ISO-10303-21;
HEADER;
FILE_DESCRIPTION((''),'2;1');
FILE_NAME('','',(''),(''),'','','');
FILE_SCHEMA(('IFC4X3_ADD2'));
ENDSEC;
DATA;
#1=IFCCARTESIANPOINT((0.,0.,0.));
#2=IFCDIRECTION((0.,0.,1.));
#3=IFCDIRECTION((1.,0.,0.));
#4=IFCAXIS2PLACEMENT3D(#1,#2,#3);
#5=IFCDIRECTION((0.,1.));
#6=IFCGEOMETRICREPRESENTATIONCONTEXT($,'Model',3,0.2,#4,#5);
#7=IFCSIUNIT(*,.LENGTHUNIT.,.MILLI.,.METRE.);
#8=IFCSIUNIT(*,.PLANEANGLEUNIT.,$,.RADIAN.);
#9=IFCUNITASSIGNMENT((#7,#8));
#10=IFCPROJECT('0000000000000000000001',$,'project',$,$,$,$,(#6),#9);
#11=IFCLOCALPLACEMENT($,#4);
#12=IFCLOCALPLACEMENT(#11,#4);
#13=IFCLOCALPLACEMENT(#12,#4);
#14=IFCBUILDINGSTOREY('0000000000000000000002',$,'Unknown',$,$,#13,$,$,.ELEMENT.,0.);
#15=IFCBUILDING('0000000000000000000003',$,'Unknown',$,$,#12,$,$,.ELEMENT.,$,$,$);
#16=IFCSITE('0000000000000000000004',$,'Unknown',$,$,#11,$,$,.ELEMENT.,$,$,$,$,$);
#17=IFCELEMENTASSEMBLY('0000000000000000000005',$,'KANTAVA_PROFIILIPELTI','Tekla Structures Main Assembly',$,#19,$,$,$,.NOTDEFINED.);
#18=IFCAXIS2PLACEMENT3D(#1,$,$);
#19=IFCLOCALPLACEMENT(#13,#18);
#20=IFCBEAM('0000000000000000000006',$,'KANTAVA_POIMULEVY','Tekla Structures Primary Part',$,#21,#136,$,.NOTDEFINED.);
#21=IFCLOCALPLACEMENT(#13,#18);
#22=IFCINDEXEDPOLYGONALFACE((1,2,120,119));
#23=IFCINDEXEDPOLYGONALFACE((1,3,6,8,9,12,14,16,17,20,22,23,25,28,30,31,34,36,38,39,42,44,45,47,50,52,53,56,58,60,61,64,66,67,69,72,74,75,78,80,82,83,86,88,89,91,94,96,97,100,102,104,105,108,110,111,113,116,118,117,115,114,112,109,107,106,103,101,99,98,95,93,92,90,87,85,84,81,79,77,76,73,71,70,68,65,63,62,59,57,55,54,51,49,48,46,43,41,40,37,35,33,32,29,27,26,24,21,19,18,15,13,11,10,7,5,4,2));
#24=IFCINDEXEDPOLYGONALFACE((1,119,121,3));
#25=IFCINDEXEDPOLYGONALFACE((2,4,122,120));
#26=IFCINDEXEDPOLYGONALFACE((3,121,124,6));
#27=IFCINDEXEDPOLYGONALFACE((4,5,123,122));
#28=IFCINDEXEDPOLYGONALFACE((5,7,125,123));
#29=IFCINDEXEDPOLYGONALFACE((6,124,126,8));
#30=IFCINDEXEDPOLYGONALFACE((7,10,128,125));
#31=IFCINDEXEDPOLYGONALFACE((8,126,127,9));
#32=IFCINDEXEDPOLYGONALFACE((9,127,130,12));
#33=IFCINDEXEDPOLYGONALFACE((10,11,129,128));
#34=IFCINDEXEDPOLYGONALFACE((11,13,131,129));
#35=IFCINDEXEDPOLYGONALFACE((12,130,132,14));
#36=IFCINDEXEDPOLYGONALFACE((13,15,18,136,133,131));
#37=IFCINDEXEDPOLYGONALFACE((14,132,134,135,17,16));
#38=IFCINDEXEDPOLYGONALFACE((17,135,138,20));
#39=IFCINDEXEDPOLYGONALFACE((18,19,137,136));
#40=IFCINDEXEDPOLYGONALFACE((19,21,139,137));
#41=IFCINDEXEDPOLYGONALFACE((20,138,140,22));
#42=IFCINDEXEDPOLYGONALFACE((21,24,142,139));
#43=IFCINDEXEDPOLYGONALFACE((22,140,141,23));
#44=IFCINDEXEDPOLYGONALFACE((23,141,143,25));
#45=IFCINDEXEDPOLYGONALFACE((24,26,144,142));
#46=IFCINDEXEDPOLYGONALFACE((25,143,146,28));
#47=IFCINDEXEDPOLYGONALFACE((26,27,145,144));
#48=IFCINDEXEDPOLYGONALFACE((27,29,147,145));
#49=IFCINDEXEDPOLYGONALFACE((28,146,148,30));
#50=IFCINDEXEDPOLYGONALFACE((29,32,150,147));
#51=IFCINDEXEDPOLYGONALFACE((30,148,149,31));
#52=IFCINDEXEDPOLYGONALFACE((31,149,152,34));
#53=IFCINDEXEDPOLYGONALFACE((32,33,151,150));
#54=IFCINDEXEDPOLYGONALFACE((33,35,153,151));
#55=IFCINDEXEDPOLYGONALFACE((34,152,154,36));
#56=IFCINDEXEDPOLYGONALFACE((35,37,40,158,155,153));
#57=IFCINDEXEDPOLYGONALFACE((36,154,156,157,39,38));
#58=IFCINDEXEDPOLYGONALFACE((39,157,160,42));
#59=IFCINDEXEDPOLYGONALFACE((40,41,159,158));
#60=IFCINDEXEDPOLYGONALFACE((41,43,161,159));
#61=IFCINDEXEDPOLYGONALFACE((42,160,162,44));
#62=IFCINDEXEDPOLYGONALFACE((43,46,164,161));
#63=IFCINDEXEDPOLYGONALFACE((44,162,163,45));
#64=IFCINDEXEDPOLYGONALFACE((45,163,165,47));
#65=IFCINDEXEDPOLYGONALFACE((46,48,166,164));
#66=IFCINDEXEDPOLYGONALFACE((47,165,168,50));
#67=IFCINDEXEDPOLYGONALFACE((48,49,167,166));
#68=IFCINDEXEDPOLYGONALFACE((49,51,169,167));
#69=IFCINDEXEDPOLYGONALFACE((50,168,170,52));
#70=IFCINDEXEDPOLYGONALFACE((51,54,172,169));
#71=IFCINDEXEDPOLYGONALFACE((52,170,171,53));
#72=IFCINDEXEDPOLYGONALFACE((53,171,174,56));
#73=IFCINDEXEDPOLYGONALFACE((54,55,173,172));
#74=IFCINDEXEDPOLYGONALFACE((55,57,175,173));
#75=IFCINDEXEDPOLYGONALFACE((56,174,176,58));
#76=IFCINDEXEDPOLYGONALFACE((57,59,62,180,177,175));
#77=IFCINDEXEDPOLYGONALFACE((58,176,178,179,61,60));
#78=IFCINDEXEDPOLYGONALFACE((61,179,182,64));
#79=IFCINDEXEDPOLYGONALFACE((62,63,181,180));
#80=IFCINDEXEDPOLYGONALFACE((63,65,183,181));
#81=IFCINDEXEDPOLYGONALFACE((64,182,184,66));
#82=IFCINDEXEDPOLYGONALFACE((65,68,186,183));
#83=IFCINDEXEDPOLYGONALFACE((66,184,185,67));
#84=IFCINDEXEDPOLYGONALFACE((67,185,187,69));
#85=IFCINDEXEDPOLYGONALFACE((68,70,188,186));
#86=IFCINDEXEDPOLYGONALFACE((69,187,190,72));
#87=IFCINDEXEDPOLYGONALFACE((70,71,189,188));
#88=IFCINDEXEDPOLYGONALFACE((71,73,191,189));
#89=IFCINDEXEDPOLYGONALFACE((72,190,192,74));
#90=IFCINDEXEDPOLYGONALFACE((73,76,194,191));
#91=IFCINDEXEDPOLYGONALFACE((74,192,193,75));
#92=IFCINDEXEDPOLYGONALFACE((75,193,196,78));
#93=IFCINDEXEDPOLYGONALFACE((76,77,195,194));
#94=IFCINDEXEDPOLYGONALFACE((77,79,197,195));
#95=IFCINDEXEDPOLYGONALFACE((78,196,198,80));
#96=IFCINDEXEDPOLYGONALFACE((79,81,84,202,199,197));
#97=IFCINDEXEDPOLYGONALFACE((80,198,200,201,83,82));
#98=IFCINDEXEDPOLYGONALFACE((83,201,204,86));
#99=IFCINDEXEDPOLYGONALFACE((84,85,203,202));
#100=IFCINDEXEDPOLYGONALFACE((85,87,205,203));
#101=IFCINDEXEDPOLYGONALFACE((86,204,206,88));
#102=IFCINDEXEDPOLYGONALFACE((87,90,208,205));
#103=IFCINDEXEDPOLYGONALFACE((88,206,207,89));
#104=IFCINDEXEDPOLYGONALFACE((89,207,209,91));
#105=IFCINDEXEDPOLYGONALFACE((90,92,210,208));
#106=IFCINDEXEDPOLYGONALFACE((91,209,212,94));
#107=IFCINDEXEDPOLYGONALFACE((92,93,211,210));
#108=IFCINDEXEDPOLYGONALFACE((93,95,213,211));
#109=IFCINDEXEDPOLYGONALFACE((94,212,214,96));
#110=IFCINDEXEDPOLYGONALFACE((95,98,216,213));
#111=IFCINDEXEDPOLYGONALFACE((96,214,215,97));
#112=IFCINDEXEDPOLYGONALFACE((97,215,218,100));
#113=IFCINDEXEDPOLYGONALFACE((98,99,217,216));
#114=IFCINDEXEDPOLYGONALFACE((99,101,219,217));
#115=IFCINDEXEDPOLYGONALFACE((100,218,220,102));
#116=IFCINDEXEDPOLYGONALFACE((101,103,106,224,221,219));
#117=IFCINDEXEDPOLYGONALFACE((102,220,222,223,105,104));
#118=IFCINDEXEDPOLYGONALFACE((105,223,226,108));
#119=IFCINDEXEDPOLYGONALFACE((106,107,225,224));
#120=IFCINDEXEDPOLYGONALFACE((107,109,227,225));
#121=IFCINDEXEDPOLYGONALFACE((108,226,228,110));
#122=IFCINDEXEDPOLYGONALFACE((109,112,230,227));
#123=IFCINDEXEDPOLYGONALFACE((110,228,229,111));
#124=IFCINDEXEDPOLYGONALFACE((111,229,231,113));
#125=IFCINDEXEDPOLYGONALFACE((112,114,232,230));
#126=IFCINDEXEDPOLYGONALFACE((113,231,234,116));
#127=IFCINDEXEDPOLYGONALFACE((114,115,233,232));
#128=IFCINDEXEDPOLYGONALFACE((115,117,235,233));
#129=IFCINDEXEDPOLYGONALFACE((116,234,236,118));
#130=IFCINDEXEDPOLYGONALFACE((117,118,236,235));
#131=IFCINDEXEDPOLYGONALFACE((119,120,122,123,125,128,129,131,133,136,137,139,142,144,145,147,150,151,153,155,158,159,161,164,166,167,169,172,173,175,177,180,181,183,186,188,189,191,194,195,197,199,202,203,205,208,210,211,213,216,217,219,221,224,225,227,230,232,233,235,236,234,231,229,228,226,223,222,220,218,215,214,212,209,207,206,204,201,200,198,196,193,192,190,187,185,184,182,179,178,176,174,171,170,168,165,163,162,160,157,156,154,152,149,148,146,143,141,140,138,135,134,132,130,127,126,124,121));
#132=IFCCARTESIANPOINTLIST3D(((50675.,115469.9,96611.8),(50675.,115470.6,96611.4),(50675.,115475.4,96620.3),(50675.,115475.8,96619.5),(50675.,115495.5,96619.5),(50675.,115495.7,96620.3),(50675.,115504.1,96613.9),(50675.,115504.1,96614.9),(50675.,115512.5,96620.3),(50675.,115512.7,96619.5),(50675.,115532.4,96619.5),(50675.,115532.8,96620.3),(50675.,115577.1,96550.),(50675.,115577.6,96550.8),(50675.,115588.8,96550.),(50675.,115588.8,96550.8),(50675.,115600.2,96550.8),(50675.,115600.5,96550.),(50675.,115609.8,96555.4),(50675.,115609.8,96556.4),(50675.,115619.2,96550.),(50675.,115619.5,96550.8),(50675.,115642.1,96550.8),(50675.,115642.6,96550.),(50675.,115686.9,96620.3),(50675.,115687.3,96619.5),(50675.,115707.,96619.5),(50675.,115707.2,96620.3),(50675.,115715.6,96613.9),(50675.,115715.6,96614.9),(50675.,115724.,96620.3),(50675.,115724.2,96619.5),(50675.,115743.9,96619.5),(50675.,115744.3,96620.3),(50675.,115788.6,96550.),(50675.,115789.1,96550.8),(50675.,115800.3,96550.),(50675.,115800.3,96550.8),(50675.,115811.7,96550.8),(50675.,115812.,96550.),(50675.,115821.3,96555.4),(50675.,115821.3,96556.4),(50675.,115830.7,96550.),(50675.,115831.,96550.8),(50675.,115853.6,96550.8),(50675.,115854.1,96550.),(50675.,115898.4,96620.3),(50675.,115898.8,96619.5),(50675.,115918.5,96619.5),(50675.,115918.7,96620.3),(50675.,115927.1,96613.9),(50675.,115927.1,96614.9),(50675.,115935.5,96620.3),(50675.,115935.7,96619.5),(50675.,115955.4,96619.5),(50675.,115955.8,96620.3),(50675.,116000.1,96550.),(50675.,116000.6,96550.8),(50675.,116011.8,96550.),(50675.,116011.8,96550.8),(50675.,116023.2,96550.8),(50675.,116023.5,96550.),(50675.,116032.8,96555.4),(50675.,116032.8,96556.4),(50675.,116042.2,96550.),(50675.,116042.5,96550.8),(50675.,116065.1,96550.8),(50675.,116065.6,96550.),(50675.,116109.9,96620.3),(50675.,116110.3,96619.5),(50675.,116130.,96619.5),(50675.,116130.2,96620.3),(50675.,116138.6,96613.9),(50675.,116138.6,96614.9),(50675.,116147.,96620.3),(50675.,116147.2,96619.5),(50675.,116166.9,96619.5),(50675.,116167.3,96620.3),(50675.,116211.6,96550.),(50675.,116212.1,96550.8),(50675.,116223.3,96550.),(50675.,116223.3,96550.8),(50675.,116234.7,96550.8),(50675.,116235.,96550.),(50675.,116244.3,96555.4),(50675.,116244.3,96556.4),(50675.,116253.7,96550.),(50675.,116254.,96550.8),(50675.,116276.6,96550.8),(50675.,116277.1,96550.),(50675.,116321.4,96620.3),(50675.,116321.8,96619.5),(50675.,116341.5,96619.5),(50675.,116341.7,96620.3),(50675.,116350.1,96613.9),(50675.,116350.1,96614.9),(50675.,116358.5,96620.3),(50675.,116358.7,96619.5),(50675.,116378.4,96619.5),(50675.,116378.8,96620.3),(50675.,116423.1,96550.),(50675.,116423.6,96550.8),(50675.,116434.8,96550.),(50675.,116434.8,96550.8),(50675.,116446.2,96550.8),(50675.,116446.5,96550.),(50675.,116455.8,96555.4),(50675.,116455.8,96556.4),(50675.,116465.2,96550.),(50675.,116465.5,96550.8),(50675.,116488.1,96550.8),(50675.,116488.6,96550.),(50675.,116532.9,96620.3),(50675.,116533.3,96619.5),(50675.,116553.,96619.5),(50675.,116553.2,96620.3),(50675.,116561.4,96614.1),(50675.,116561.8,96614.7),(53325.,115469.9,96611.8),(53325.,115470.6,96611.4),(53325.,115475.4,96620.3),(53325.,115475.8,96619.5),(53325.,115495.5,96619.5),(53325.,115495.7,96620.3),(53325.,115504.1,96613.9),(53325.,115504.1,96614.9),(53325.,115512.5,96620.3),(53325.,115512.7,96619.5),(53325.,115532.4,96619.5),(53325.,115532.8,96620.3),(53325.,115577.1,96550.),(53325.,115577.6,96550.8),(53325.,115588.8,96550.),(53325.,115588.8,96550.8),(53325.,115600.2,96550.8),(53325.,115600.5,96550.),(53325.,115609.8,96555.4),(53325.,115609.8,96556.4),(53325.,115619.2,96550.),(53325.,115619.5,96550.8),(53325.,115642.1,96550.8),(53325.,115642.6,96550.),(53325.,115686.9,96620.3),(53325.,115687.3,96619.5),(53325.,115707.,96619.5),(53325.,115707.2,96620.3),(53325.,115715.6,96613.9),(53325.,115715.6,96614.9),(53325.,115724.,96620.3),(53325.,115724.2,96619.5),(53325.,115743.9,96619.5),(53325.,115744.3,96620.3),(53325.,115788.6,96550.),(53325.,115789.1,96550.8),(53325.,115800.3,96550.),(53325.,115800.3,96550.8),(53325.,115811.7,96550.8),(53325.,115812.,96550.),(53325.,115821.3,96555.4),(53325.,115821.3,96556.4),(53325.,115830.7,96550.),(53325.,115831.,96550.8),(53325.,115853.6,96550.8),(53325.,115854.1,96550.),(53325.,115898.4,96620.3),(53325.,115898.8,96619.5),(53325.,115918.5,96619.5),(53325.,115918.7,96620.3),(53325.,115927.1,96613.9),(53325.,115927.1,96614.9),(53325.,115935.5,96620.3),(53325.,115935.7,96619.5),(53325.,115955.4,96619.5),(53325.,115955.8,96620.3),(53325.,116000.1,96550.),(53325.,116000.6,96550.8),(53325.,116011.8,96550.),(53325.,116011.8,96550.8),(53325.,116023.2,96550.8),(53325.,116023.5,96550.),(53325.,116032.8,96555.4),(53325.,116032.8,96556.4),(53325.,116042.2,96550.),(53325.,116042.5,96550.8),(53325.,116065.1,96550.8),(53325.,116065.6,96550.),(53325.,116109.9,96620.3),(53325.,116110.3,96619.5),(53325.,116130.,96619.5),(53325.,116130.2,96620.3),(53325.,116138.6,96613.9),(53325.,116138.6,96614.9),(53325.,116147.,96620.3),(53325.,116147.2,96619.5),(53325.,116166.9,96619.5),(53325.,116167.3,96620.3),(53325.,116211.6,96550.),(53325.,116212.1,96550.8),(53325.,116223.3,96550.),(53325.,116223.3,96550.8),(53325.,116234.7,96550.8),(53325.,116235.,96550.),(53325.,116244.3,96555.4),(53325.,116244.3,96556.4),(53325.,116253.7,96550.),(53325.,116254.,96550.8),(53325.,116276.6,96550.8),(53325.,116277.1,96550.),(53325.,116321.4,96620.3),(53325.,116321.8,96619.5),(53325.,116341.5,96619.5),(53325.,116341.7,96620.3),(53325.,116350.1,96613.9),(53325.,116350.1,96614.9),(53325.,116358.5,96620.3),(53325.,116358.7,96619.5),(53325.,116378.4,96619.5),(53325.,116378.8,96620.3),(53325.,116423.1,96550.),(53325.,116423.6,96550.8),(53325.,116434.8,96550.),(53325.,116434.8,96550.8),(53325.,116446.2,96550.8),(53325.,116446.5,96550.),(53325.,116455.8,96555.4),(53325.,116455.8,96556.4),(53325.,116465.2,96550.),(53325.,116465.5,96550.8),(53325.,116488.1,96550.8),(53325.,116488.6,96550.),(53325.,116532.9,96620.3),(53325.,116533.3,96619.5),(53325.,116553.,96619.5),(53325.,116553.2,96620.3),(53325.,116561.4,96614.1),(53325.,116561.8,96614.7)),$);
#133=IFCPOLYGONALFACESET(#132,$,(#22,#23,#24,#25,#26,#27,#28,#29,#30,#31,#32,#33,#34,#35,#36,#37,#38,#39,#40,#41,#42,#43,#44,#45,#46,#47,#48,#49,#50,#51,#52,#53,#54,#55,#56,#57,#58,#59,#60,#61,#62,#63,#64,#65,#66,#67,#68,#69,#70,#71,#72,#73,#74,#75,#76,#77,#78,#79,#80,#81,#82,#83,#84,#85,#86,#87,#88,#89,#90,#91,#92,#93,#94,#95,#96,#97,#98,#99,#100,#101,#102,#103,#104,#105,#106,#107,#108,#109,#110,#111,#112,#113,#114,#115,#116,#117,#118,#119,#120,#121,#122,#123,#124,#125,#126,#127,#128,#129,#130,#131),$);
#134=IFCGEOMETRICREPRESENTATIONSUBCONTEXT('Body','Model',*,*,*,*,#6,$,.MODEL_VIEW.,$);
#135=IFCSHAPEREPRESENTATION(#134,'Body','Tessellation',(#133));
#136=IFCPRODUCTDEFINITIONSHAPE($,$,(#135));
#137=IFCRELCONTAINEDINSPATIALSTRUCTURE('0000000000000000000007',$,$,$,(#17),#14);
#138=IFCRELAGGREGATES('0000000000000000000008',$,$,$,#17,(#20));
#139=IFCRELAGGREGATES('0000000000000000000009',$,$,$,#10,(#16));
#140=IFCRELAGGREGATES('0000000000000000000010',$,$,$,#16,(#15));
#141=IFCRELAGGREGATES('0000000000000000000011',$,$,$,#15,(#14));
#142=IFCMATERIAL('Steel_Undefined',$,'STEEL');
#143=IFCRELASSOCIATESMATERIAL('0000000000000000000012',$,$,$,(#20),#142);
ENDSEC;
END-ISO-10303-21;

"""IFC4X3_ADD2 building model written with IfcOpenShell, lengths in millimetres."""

from ifc_helpers import new_model, si_unit, direction, frame, origin_with_axes, place, context, subcontext, project, spatial, line, indexed_curve, outline, extrude, material, element, aggregate, save


model = new_model("IFC4X3_ADD2")

# Units and contexts
model_context = context("Model", 3, precision=0.2, world=origin_with_axes(), true_north=direction((0.0, 1.0)))
body_context = subcontext(model_context, "Body", "Model", "MODEL_VIEW")
ifc_project = project(units=[si_unit("LENGTHUNIT", "METRE", prefix="MILLI"), si_unit("PLANEANGLEUNIT", "RADIAN")], contexts=[model_context])

# Site, building, storey
site_placement = place(None, origin_with_axes())
site = spatial("IfcSite", under=ifc_project, at=site_placement, Name="Unknown", CompositionType="ELEMENT")
building_placement = place(site_placement, origin_with_axes())
building = spatial("IfcBuilding", under=site, at=building_placement, Name="Unknown", CompositionType="ELEMENT")
storey_placement = place(building_placement, origin_with_axes())
storey = spatial("IfcBuildingStorey", under=building, at=storey_placement, Name="Unknown", CompositionType="ELEMENT", Elevation=0.0)

# Element assembly, beam
ifc_material_1 = material(Name="Steel_Undefined", Category="STEEL")
assembly_1_placement = place(storey_placement, frame((53325.0, 116032.8, 96585.2), z_axis=(0.0, 1.0, 0.0), x_axis=(-1.0, 0.0, 0.0)))
assembly_1 = element("IfcElementAssembly", 1, at=assembly_1_placement, inside=storey, Name="KANTAVA_PROFIILIPELTI", Description="Tekla Structures Main Assembly", PredefinedType="NOTDEFINED")
beam_1_placement = place(assembly_1_placement, origin_with_axes())
beam_1 = element("IfcBeam", 2, at=beam_1_placement, material=ifc_material_1, Name="KANTAVA_POIMULEVY", Description="Tekla Structures Primary Part", PredefinedType="NOTDEFINED", context=body_context, shape_type="SolidModel", body=[
    extrude(outline(indexed_curve([(529.0, 29.6), (520.4, 35.1), (500.0, 35.1), (455.3, -34.4), (432.6, -34.4), (423.0, -28.8), (413.4, -34.4), (402.0, -34.4), (390.7, -34.4), (346.0, 35.1), (325.6, 35.1), (317.2, 29.7), (308.9, 35.1), (288.5, 35.1), (243.8, -34.4), (221.1, -34.4), (211.5, -28.8), (201.9, -34.4), (190.5, -34.4), (179.2, -34.4), (134.5, 35.1), (114.1, 35.1), (105.8, 29.7), (97.4, 35.1), (77.0, 35.1), (32.3, -34.4), (9.6, -34.4), (0.0, -28.8), (-9.6, -34.4), (-21.0, -34.4), (-32.3, -34.4), (-77.0, 35.1), (-97.4, 35.1), (-105.8, 29.7), (-114.1, 35.1), (-134.5, 35.1), (-179.2, -34.4), (-201.9, -34.4), (-211.5, -28.8), (-221.1, -34.4), (-232.5, -34.4), (-243.8, -34.4), (-288.5, 35.1), (-308.9, 35.1), (-317.2, 29.7), (-325.6, 35.1), (-346.0, 35.1), (-390.7, -34.4), (-413.4, -34.4), (-423.0, -28.8), (-432.6, -34.4), (-444.0, -34.4), (-455.3, -34.4), (-500.0, 35.1), (-520.4, 35.1), (-528.8, 29.7), (-537.1, 35.1), (-557.5, 35.1), (-562.9, 26.7), (-562.2, 26.2), (-557.0, 34.4), (-537.4, 34.4), (-528.8, 28.8), (-520.1, 34.4), (-500.5, 34.4), (-455.7, -35.1), (-444.0, -35.1), (-432.4, -35.1), (-423.0, -29.7), (-413.6, -35.1), (-390.3, -35.1), (-345.5, 34.4), (-325.9, 34.4), (-317.2, 28.8), (-308.6, 34.4), (-289.0, 34.4), (-244.2, -35.1), (-232.5, -35.1), (-220.9, -35.1), (-211.5, -29.7), (-202.1, -35.1), (-178.8, -35.1), (-134.0, 34.4), (-114.4, 34.4), (-105.8, 28.8), (-97.1, 34.4), (-77.5, 34.4), (-32.7, -35.1), (-21.0, -35.1), (-9.4, -35.1), (0.0, -29.7), (9.4, -35.1), (32.7, -35.1), (77.5, 34.4), (97.1, 34.4), (105.8, 28.8), (114.4, 34.4), (134.0, 34.4), (178.8, -35.1), (190.5, -35.1), (202.1, -35.1), (211.5, -29.7), (220.9, -35.1), (244.2, -35.1), (289.0, 34.4), (308.6, 34.4), (317.2, 28.8), (325.9, 34.4), (345.5, 34.4), (390.3, -35.1), (402.0, -35.1), (413.6, -35.1), (423.0, -29.7), (432.4, -35.1), (455.7, -35.1), (500.5, 34.4), (520.1, 34.4), (528.5, 28.9)], segments=[line(1, 2, 3, 4, 5, 6, 7, 8, 9, 10, 11, 12, 13, 14, 15, 16, 17, 18, 19, 20, 21, 22, 23, 24, 25, 26, 27, 28, 29, 30, 31, 32, 33, 34, 35, 36, 37, 38, 39, 40, 41, 42, 43, 44, 45, 46, 47, 48, 49, 50, 51, 52, 53, 54, 55, 56, 57, 58, 59, 60, 61, 62, 63, 64, 65, 66, 67, 68, 69, 70, 71, 72, 73, 74, 75, 76, 77, 78, 79, 80, 81, 82, 83, 84, 85, 86, 87, 88, 89, 90, 91, 92, 93, 94, 95, 96, 97, 98, 99, 100, 101, 102, 103, 104, 105, 106, 107, 108, 109, 110, 111, 112, 113, 114, 115, 116, 117, 118, 1)])), frame((0.0, 0.0, 0.0), z_axis=(-1.0, 0.0, 0.0), x_axis=(0.0, 0.0, 1.0)), (0.0, 0.0, -1.0), 2650.0),
])
aggregate(assembly_1, [beam_1])

save(model, "model.ifc")
